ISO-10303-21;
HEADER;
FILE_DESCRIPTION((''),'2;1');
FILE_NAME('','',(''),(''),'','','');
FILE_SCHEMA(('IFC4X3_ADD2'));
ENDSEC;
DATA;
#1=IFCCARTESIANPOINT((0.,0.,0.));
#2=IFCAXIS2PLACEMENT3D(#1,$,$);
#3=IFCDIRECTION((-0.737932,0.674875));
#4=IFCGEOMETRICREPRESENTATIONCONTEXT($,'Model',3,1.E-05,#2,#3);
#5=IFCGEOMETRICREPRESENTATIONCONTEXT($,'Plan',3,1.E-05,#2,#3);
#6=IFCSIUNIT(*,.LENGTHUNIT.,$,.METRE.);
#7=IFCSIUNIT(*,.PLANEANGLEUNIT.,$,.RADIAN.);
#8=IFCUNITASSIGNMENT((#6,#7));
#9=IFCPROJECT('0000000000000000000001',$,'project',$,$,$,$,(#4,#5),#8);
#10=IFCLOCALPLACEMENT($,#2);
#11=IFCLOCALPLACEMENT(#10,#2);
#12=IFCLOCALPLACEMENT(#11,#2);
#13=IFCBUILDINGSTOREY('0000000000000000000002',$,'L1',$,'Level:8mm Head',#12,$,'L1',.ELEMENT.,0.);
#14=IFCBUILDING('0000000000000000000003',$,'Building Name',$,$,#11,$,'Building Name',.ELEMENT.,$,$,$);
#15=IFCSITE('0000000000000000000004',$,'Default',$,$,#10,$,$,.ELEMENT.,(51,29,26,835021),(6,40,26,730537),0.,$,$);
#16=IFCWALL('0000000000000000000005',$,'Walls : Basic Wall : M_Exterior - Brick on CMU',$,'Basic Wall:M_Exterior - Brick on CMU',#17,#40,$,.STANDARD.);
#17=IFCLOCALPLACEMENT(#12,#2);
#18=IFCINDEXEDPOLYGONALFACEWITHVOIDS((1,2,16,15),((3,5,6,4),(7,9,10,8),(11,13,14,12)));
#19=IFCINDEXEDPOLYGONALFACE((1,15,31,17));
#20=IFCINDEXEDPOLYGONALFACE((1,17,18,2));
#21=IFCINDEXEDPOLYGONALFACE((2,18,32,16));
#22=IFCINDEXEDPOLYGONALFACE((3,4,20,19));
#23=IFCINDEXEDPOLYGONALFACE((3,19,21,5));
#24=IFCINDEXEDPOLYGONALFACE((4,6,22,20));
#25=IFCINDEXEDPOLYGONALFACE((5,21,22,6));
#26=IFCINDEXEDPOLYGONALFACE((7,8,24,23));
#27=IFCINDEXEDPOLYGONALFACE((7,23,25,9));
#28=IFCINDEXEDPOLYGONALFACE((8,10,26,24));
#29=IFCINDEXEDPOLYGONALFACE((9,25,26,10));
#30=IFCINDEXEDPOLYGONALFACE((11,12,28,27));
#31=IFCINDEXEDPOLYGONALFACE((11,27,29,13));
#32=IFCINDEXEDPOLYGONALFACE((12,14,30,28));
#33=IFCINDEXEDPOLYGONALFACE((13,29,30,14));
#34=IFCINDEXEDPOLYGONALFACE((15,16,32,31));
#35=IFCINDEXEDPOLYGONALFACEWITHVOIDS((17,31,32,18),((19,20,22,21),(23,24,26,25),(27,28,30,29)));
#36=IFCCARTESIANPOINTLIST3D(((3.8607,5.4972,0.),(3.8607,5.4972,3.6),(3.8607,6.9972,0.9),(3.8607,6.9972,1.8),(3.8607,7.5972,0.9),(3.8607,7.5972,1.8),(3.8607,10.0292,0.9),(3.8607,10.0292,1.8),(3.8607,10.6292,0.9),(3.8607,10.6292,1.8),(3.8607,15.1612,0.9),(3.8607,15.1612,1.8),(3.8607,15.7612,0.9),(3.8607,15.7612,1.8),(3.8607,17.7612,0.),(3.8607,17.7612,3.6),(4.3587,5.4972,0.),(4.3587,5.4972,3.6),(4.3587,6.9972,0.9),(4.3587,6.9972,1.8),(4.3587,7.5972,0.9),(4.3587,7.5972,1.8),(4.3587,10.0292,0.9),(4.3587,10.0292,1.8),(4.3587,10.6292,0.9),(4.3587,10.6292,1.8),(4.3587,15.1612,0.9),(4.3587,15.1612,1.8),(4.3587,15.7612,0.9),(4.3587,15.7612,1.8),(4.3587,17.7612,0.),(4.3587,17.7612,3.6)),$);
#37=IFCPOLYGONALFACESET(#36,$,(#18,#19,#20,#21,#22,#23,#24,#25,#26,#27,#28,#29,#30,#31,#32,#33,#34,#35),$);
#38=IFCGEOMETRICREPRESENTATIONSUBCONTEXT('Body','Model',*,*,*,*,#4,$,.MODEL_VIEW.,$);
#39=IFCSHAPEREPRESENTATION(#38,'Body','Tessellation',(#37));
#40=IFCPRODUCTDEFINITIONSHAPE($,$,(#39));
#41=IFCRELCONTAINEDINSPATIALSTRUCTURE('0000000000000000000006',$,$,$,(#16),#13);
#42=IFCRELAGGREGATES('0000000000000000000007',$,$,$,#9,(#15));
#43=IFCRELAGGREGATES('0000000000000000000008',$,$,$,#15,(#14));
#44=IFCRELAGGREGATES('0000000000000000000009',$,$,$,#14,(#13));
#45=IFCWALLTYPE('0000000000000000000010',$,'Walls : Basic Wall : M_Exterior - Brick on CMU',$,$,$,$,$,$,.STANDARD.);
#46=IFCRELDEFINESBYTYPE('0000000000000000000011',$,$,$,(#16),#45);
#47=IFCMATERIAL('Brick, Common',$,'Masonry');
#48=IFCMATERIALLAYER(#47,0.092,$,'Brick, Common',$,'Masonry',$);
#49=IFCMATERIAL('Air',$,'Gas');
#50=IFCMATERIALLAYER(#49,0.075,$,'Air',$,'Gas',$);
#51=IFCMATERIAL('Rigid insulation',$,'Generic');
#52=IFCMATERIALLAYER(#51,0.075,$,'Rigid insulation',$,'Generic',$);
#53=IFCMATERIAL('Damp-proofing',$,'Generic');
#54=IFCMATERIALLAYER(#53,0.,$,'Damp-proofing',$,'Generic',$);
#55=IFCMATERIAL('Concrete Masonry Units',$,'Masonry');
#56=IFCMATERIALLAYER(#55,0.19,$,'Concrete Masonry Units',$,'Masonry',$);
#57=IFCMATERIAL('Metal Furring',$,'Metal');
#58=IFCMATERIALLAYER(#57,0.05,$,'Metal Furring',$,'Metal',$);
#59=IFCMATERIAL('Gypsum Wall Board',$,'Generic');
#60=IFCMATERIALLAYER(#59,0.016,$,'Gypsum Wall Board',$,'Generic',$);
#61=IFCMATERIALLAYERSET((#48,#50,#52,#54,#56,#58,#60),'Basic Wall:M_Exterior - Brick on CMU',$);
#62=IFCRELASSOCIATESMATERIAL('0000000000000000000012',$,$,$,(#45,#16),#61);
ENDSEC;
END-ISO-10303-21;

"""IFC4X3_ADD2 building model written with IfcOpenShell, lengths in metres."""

from ifc_helpers import new_model, si_unit, direction, frame, frame_2d, origin, origin_2d_with_axis, place, context, subcontext, project, spatial, rectangle, extrude, material, layer, layer_set, type_object, element, save


model = new_model("IFC4X3_ADD2")

# Units and contexts
model_context = context("Model", 3, precision=1e-05, world=origin(), true_north=direction((-0.737932, 0.674875)))
plan_context = context("Plan", 3, precision=1e-05, world=origin(), true_north=direction((-0.737932, 0.674875)))
body_context = subcontext(model_context, "Body", "Model", "MODEL_VIEW")
ifc_project = project(units=[si_unit("LENGTHUNIT", "METRE"), si_unit("PLANEANGLEUNIT", "RADIAN")], contexts=[model_context, plan_context])

# Site, building, storey
site_placement = place(None, origin())
site = spatial("IfcSite", under=ifc_project, at=site_placement, Name="Default", CompositionType="ELEMENT", RefLatitude=(51, 29, 26, 835021), RefLongitude=(6, 40, 26, 730537), RefElevation=0.0)
building_placement = place(site_placement, origin())
building = spatial("IfcBuilding", under=site, at=building_placement, Name="Building Name", LongName="Building Name", CompositionType="ELEMENT")
storey_placement = place(building_placement, origin())
storey = spatial("IfcBuildingStorey", under=building, at=storey_placement, Name="L1", ObjectType="Level:8mm Head", LongName="L1", CompositionType="ELEMENT", Elevation=0.0)

# Shared definitions
ifc_material_1 = material(Name="Brick, Common", Category="Masonry")
ifc_layer_1 = layer(ifc_material_1, 0.092, Name="Brick, Common", Category="Masonry")
ifc_material_2 = material(Name="Air", Category="Gas")
ifc_layer_2 = layer(ifc_material_2, 0.075, Name="Air", Category="Gas")
ifc_material_3 = material(Name="Rigid insulation", Category="Generic")
ifc_layer_3 = layer(ifc_material_3, 0.075, Name="Rigid insulation", Category="Generic")
ifc_material_4 = material(Name="Damp-proofing", Category="Generic")
ifc_layer_4 = layer(ifc_material_4, 0.0, Name="Damp-proofing", Category="Generic")
ifc_material_5 = material(Name="Concrete Masonry Units", Category="Masonry")
ifc_layer_5 = layer(ifc_material_5, 0.19, Name="Concrete Masonry Units", Category="Masonry")
ifc_material_6 = material(Name="Metal Furring", Category="Metal")
ifc_layer_6 = layer(ifc_material_6, 0.05, Name="Metal Furring", Category="Metal")
ifc_material_7 = material(Name="Gypsum Wall Board", Category="Generic")
ifc_layer_7 = layer(ifc_material_7, 0.016, Name="Gypsum Wall Board", Category="Generic")
ifc_layer_set_1 = layer_set([ifc_layer_1, ifc_layer_2, ifc_layer_3, ifc_layer_4, ifc_layer_5, ifc_layer_6, ifc_layer_7], Name="Basic Wall:M_Exterior - Brick on CMU")
wall_type = type_object("IfcWallType", Name="Walls : Basic Wall : M_Exterior - Brick on CMU", PredefinedType="STANDARD", material=ifc_layer_set_1)

# Wall, openings
wall_1_placement = place(storey_placement, frame((4.1097, 5.4972, 0.0), z_axis=(0.0, 0.0, 1.0), x_axis=(0.0, 1.0, 0.0)))
wall_1 = element("IfcWall", 1, at=wall_1_placement, inside=storey, type_object=wall_type, material=ifc_layer_set_1, Name="Walls : Basic Wall : M_Exterior - Brick on CMU", ObjectType="Basic Wall:M_Exterior - Brick on CMU", PredefinedType="STANDARD", context=body_context, shape_type="SweptSolid", body=[
    extrude(rectangle(XDim=12.264, YDim=0.498, at=frame_2d((6.132, 0.0), x_axis=(-1.0, 0.0))), origin(), (0.0, 0.0, 1.0), 3.6),
])
opening_1_placement = place(wall_1_placement, frame((-5.4972, 4.1097, 0.9)))
element("IfcOpeningElement", 2, at=opening_1_placement, cuts=wall_1, PredefinedType="OPENING", context=body_context, shape_type="SweptSolid", body=[
    extrude(rectangle(XDim=0.9, YDim=0.6, at=frame_2d((0.0, 0.0), x_axis=(1.0, 0.0))), frame((15.4612, -5.8827, 0.45), z_axis=(0.0, 1.0, 0.0), x_axis=(0.0, 0.0, -1.0)), (0.0, 0.0, 1.0), 3.048),
])
opening_2_placement = place(wall_1_placement, frame((-5.4972, 4.1097, 0.9)))
element("IfcOpeningElement", 3, at=opening_2_placement, cuts=wall_1, PredefinedType="OPENING", context=body_context, shape_type="SweptSolid", body=[
    extrude(rectangle(XDim=0.9, YDim=0.6, at=frame_2d((0.0, 0.0), x_axis=(1.0, 0.0))), frame((10.3292, -5.8827, 0.45), z_axis=(0.0, 1.0, 0.0), x_axis=(0.0, 0.0, -1.0)), (0.0, 0.0, 1.0), 3.048),
])
opening_3_placement = place(wall_1_placement, frame((-5.4972, 4.1097, 0.9)))
element("IfcOpeningElement", 4, at=opening_3_placement, cuts=wall_1, PredefinedType="OPENING", context=body_context, shape_type="SweptSolid", body=[
    extrude(rectangle(XDim=0.9, YDim=0.6, at=origin_2d_with_axis()), frame((7.2972, -5.8827, 0.45), z_axis=(0.0, 1.0, 0.0), x_axis=(0.0, 0.0, -1.0)), (0.0, 0.0, 1.0), 3.048),
])

save(model, "model.ifc")
